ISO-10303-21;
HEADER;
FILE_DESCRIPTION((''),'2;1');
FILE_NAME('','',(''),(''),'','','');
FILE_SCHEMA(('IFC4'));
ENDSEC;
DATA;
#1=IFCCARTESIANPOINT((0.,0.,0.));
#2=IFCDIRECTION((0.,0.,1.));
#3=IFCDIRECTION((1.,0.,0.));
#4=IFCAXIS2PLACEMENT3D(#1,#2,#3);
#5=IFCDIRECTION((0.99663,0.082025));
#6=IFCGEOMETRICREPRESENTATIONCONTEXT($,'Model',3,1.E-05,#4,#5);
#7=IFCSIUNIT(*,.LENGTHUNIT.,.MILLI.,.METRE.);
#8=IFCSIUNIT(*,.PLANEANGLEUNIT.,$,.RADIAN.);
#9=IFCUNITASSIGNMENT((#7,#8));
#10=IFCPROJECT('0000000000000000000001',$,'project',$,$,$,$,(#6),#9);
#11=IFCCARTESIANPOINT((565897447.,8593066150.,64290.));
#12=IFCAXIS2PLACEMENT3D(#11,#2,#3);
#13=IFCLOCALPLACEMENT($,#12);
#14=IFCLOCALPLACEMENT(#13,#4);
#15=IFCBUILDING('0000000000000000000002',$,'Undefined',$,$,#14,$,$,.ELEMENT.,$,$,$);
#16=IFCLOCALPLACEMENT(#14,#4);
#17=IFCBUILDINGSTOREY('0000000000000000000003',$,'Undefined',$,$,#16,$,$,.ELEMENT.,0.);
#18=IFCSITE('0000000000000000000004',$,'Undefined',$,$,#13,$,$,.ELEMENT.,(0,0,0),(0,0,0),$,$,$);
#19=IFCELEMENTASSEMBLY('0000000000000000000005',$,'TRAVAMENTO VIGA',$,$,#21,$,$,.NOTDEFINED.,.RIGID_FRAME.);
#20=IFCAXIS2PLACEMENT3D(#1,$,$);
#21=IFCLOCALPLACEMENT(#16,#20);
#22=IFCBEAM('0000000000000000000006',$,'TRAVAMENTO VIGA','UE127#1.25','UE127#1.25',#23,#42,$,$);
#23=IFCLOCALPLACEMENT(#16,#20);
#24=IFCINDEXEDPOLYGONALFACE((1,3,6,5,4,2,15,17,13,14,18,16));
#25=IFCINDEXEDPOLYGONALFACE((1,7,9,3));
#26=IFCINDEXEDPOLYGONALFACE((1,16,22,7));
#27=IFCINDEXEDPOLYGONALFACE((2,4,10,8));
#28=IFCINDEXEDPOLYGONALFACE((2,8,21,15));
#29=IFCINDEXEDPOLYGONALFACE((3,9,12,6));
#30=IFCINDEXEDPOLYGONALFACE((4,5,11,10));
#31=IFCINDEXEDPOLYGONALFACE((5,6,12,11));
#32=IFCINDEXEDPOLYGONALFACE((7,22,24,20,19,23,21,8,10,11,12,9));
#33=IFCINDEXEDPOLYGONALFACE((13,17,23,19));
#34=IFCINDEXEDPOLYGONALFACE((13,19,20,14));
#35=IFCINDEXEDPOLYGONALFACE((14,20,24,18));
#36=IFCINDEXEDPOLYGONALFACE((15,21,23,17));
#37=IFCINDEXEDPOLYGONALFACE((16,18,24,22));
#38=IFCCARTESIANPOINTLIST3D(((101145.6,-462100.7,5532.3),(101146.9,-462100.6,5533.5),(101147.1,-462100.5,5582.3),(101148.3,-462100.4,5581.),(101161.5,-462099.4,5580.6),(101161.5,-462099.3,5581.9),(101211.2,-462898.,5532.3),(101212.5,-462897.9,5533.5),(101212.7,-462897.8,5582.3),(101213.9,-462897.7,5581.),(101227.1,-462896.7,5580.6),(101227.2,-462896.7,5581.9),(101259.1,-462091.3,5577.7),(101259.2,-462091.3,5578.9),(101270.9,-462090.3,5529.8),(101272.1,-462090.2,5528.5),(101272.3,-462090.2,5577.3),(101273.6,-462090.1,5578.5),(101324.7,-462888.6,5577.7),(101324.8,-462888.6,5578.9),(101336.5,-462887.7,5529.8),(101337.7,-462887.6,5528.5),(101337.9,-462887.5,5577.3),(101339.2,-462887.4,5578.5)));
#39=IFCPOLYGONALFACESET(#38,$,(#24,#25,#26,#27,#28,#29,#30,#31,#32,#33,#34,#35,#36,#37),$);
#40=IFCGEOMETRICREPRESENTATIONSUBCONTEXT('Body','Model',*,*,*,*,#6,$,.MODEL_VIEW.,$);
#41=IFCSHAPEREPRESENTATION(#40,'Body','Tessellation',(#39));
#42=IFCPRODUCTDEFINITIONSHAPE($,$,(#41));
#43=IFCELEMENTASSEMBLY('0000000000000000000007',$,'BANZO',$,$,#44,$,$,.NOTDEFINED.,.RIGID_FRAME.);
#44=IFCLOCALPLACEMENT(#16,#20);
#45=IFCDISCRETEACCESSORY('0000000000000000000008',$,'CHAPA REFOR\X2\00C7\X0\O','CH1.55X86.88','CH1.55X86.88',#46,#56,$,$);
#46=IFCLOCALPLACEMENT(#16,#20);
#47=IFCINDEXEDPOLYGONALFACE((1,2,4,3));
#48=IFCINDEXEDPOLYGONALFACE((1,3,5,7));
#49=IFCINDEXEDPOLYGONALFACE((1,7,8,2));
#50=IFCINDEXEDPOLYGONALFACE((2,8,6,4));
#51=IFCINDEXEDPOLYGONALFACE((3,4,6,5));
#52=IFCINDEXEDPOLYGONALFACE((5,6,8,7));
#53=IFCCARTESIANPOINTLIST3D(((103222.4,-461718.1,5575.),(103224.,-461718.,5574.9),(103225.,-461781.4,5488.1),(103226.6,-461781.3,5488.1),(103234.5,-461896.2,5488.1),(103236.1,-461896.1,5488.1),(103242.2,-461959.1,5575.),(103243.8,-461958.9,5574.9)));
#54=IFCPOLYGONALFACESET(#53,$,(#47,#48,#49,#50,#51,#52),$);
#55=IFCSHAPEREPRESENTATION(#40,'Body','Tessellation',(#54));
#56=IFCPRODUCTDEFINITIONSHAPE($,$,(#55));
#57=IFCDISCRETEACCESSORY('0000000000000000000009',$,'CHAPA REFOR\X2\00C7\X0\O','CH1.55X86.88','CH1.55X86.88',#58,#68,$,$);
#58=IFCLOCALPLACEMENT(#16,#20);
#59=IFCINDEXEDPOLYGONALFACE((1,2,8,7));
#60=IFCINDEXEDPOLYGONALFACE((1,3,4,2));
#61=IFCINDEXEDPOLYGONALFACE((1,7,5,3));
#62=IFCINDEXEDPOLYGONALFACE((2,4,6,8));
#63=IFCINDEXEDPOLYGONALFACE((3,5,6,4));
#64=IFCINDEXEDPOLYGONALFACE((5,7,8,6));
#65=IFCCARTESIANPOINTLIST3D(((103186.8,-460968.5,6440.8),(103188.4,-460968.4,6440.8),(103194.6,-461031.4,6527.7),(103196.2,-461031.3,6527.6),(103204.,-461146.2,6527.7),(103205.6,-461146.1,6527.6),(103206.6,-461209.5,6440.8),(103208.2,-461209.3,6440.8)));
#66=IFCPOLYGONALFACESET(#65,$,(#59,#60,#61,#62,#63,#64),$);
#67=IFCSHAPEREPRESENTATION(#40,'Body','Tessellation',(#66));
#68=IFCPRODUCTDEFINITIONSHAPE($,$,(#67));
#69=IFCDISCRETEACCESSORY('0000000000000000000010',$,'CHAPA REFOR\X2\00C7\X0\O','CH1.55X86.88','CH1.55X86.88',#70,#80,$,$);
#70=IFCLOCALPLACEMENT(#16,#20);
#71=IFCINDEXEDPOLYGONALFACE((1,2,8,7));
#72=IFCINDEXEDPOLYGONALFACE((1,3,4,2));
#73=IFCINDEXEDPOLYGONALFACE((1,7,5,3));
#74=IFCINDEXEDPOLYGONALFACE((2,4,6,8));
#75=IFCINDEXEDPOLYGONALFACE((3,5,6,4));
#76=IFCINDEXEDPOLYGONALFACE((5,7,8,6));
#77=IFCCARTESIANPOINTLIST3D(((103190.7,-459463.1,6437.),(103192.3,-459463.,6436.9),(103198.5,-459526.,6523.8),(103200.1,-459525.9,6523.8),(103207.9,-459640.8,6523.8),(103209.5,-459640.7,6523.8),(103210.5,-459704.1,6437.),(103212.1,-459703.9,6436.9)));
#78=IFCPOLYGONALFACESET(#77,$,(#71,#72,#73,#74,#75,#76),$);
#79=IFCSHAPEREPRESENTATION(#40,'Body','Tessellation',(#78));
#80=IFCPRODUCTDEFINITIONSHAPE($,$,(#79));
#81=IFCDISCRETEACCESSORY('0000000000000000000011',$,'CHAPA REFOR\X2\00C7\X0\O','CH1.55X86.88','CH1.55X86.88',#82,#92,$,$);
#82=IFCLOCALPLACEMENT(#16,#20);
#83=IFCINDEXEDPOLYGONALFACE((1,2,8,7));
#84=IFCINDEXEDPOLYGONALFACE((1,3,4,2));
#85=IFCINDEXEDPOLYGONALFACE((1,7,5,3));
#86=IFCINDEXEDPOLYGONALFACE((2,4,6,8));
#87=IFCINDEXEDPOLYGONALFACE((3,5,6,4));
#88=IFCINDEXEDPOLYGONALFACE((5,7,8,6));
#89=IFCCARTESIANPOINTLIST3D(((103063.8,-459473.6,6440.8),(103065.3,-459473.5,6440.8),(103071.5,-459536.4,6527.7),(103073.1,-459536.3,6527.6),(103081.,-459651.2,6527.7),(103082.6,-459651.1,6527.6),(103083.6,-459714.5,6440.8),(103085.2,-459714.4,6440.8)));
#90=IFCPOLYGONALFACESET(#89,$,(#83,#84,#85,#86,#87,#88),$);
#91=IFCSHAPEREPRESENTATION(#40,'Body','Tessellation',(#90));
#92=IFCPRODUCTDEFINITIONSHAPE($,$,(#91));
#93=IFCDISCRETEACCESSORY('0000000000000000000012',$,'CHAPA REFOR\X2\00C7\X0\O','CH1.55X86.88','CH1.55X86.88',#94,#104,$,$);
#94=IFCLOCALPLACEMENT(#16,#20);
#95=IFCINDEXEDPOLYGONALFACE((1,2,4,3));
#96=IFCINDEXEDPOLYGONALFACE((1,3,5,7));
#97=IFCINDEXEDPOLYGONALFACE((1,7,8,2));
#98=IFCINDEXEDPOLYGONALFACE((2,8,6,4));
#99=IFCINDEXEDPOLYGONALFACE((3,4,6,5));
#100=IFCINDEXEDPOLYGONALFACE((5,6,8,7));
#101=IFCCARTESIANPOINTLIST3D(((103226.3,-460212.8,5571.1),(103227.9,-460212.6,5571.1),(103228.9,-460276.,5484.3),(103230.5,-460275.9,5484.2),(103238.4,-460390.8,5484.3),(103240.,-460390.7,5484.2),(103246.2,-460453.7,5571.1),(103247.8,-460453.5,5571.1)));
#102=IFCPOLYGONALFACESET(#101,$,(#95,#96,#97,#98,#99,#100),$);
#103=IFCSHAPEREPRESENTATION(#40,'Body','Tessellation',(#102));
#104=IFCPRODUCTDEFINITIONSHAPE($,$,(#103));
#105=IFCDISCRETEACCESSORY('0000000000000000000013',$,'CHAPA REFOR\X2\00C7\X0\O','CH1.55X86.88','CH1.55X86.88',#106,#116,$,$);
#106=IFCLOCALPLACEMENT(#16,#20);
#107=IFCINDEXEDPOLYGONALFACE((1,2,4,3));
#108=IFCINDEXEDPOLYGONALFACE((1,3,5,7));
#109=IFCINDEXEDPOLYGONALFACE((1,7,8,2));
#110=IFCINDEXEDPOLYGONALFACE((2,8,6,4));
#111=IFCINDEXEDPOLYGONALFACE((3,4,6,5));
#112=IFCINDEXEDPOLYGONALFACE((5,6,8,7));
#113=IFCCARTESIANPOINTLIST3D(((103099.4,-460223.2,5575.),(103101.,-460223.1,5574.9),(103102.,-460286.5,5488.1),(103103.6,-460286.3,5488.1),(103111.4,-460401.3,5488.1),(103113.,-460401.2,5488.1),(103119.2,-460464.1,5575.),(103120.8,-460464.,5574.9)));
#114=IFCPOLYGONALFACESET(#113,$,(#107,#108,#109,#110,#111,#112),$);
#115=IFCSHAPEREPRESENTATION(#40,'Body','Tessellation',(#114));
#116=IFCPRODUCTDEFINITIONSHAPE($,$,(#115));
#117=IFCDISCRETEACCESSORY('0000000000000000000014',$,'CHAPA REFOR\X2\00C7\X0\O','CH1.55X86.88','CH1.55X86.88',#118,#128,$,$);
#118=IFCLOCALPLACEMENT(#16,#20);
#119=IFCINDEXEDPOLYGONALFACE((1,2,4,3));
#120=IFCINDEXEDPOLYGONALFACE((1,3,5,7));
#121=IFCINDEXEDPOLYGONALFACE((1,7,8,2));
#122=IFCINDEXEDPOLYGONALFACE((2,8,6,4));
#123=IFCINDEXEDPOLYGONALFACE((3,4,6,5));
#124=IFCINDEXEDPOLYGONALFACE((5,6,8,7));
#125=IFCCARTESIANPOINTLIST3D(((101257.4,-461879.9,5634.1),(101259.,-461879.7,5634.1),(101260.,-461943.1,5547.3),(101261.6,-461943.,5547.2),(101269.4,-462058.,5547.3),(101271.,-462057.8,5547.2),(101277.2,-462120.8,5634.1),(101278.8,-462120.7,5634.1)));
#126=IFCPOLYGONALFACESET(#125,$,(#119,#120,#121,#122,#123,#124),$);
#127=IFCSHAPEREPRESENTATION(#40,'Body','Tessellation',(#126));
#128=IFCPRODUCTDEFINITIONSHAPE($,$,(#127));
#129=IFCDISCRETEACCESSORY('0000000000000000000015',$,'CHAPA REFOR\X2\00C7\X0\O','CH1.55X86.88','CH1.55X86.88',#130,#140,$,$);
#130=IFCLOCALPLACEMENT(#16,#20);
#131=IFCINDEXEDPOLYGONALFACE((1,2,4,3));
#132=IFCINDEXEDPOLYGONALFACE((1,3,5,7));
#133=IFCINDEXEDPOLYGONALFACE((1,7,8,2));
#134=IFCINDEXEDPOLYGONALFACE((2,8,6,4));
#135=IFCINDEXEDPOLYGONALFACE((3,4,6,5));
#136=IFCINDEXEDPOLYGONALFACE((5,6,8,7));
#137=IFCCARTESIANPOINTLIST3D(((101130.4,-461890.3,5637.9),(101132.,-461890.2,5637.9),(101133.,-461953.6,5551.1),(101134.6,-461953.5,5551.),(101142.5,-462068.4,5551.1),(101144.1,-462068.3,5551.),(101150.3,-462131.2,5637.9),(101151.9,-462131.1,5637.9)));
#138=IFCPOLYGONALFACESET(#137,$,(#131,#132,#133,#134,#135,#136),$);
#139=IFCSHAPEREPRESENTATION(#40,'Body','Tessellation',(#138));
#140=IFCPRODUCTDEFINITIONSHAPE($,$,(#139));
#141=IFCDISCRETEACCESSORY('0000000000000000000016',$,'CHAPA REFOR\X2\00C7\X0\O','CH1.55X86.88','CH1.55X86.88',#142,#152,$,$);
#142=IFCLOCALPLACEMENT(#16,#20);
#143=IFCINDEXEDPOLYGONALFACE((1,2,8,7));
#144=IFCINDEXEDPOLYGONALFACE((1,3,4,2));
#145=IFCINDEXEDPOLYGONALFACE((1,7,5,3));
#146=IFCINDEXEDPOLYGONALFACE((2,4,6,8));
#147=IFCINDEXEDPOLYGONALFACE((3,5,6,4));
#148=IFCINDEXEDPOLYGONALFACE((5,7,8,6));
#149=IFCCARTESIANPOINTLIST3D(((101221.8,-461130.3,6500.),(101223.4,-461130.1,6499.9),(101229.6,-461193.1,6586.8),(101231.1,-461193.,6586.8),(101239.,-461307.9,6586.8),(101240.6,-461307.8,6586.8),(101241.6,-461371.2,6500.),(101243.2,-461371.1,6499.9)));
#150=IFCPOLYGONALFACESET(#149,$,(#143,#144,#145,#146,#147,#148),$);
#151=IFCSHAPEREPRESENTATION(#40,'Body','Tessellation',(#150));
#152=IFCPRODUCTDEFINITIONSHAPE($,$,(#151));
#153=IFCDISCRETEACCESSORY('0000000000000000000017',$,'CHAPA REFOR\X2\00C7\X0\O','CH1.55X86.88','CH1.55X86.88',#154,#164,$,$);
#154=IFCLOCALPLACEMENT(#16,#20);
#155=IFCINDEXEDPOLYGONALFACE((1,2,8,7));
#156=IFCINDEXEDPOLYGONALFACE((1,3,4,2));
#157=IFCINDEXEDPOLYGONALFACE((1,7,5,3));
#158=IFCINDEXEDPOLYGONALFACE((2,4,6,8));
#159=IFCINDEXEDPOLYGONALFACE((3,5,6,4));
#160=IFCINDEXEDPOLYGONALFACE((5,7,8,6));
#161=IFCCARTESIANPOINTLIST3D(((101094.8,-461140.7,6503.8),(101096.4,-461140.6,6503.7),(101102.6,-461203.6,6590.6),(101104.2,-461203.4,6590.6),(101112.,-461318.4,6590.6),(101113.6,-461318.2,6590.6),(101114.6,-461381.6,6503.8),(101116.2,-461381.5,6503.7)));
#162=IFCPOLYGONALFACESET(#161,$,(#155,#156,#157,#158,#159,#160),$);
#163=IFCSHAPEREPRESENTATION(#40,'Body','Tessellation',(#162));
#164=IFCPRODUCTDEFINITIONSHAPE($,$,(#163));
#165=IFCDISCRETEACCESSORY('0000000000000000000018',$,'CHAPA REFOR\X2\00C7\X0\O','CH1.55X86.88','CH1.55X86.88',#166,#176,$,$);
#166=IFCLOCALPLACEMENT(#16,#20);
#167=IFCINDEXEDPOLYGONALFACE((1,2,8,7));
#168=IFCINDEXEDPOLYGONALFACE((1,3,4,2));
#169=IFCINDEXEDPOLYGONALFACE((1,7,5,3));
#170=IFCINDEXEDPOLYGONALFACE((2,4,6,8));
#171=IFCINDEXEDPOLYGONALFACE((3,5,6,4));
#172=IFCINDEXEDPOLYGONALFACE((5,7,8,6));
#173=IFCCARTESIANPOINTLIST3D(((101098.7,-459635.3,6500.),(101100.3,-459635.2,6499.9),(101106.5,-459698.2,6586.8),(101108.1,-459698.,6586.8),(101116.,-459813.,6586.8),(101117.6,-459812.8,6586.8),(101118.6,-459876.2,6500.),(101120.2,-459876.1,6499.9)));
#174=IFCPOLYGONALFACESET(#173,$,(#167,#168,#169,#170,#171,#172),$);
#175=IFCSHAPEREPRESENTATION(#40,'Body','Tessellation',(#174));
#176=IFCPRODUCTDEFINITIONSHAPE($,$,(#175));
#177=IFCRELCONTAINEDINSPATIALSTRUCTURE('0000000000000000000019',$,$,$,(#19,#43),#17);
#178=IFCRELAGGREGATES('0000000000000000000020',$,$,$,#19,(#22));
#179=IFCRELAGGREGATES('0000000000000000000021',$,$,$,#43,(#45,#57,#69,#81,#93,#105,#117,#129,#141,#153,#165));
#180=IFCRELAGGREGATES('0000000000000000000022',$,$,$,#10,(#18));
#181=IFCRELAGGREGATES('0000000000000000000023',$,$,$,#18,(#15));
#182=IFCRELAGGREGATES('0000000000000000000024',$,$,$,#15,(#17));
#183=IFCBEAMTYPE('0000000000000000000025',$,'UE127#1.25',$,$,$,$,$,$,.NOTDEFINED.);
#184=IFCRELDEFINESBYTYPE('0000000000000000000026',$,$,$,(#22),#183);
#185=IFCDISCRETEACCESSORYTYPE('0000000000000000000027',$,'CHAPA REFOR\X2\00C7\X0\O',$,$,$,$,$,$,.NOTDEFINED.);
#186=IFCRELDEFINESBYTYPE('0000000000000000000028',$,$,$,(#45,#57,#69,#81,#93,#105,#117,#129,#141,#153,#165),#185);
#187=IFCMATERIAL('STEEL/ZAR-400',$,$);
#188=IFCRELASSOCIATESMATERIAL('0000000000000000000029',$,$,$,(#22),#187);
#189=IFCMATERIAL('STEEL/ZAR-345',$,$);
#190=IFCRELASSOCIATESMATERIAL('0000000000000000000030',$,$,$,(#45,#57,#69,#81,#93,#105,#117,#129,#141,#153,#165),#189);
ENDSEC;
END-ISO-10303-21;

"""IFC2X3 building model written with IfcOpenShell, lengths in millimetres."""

from ifc_helpers import new_model, si_unit, direction, frame, frame_2d, origin_with_axes, place, context, subcontext, project, spatial, polyline, c_section, outline, extrude, material, type_object, element, aggregate, save


model = new_model("IFC2X3")

# Units and contexts
model_context = context("Model", 3, precision=1e-05, world=origin_with_axes(), true_north=direction((0.99663, 0.082025)))
body_context = subcontext(model_context, "Body", "Model", "MODEL_VIEW")
ifc_project = project(units=[si_unit("LENGTHUNIT", "METRE", prefix="MILLI"), si_unit("PLANEANGLEUNIT", "RADIAN")], contexts=[model_context])

# Site, building, storey
site_placement = place(None, frame((565897447.0, 8593066150.0, 64290.0), z_axis=(0.0, 0.0, 1.0), x_axis=(1.0, 0.0, 0.0)))
site = spatial("IfcSite", under=ifc_project, at=site_placement, Name="Undefined", CompositionType="ELEMENT", RefLatitude=(0, 0, 0), RefLongitude=(0, 0, 0))
building_placement = place(site_placement, origin_with_axes())
building = spatial("IfcBuilding", under=site, at=building_placement, Name="Undefined", CompositionType="ELEMENT")
storey_placement = place(building_placement, origin_with_axes())
storey = spatial("IfcBuildingStorey", under=building, at=storey_placement, Name="Undefined", CompositionType="ELEMENT", Elevation=0.0)

# Element assembly, beam
assembly_1_placement = place(storey_placement, origin_with_axes())
assembly_1 = element("IfcElementAssembly", 1, at=assembly_1_placement, inside=storey, Name="TRAVAMENTO VIGA", AssemblyPlace="NOTDEFINED", PredefinedType="RIGID_FRAME")
ifc_material_1 = material(Name="STEEL/ZAR-400")
beam_type = type_object("IfcBeamType", Name="UE127#1.25", PredefinedType="NOTDEFINED")
beam_placement = place(assembly_1_placement, frame((101209.6, -462095.4, 5555.4), z_axis=(0.996182, 0.081989, -0.029987), x_axis=(0.082025, -0.99663, 0.0)))
beam = element("IfcBeam", 2, at=beam_placement, type_object=beam_type, material=ifc_material_1, Name="TRAVAMENTO VIGA", Description="UE127#1.25", ObjectType="UE127#1.25", context=body_context, shape_type="SweptSolid", body=[
    extrude(c_section(Depth=127.0, Width=50.0, WallThickness=1.2, Girth=14.5, at=frame_2d((0.0, 0.0), x_axis=(1.0, 0.0))), frame((800.0, 0.0, 0.0), z_axis=(-1.0, 0.0, 0.0), x_axis=(0.0, -1.0, 0.0)), (0.0, 0.0, 1.0), 800.0),
])
aggregate(assembly_1, [beam])

# Element assembly, discrete accessories
assembly_2_placement = place(storey_placement, origin_with_axes())
assembly_2 = element("IfcElementAssembly", 3, at=assembly_2_placement, inside=storey, Name="BANZO", AssemblyPlace="NOTDEFINED", PredefinedType="RIGID_FRAME")
ifc_material_2 = material(Name="STEEL/ZAR-345")
discrete_accessory_type_1 = type_object("IfcDiscreteAccessoryType", Name="CHAPA REFORÇO")
discrete_accessory_1_placement = place(assembly_2_placement, frame((103223.2, -461718.1, 5574.9), z_axis=(0.996182, 0.081989, -0.029987), x_axis=(0.082025, -0.99663, 0.0)))
discrete_accessory_1 = element("IfcDiscreteAccessory", 4, at=discrete_accessory_1_placement, type_object=discrete_accessory_type_1, material=ifc_material_2, Name="CHAPA REFORÇO", Description="CH1.55X86.88", ObjectType="CH1.55X86.88", context=body_context, shape_type="SweptSolid", body=[
    extrude(outline(polyline([(0.0, 0.0), (241.7, 0.0), (178.5, 86.9), (63.3, 86.9), (0.0, 0.0)])), frame((0.0, 0.0, -0.8), z_axis=(0.0, 0.0, 1.0), x_axis=(1.0, 0.0, 0.0)), (0.0, 0.0, 1.0), 1.6),
])
discrete_accessory_2_placement = place(assembly_2_placement, frame((103207.4, -461209.4, 6440.8), z_axis=(0.996182, 0.081989, -0.029987), x_axis=(-0.082025, 0.99663, 0.0)))
discrete_accessory_2 = element("IfcDiscreteAccessory", 5, at=discrete_accessory_2_placement, type_object=discrete_accessory_type_1, material=ifc_material_2, Name="CHAPA REFORÇO", Description="CH1.55X86.88", ObjectType="CH1.55X86.88", context=body_context, shape_type="SweptSolid", body=[
    extrude(outline(polyline([(0.0, 0.0), (241.7, 0.0), (178.5, 86.9), (63.3, 86.9), (0.0, 0.0)])), frame((0.0, 0.0, -0.8), z_axis=(0.0, 0.0, 1.0), x_axis=(1.0, 0.0, 0.0)), (0.0, 0.0, 1.0), 1.6),
])
discrete_accessory_3_placement = place(assembly_2_placement, frame((103211.3, -459704.0, 6437.0), z_axis=(0.996182, 0.081989, -0.029987), x_axis=(-0.082025, 0.99663, 0.0)))
discrete_accessory_3 = element("IfcDiscreteAccessory", 6, at=discrete_accessory_3_placement, type_object=discrete_accessory_type_1, material=ifc_material_2, Name="CHAPA REFORÇO", Description="CH1.55X86.88", ObjectType="CH1.55X86.88", context=body_context, shape_type="SweptSolid", body=[
    extrude(outline(polyline([(0.0, 0.0), (241.7, 0.0), (178.5, 86.9), (63.3, 86.9), (0.0, 0.0)])), frame((0.0, 0.0, -0.8), z_axis=(0.0, 0.0, 1.0), x_axis=(1.0, 0.0, 0.0)), (0.0, 0.0, 1.0), 1.6),
])
discrete_accessory_4_placement = place(assembly_2_placement, frame((103084.4, -459714.5, 6440.8), z_axis=(0.996182, 0.081989, -0.029987), x_axis=(-0.082025, 0.99663, 0.0)))
discrete_accessory_4 = element("IfcDiscreteAccessory", 7, at=discrete_accessory_4_placement, type_object=discrete_accessory_type_1, material=ifc_material_2, Name="CHAPA REFORÇO", Description="CH1.55X86.88", ObjectType="CH1.55X86.88", context=body_context, shape_type="SweptSolid", body=[
    extrude(outline(polyline([(0.0, 0.0), (241.7, 0.0), (178.5, 86.9), (63.3, 86.9), (0.0, 0.0)])), frame((0.0, 0.0, -0.8), z_axis=(0.0, 0.0, 1.0), x_axis=(1.0, 0.0, 0.0)), (0.0, 0.0, 1.0), 1.6),
])
discrete_accessory_5_placement = place(assembly_2_placement, frame((103227.1, -460212.7, 5571.1), z_axis=(0.996182, 0.081989, -0.029987), x_axis=(0.082025, -0.99663, 0.0)))
discrete_accessory_5 = element("IfcDiscreteAccessory", 8, at=discrete_accessory_5_placement, type_object=discrete_accessory_type_1, material=ifc_material_2, Name="CHAPA REFORÇO", Description="CH1.55X86.88", ObjectType="CH1.55X86.88", context=body_context, shape_type="SweptSolid", body=[
    extrude(outline(polyline([(0.0, 0.0), (241.7, 0.0), (178.5, 86.9), (63.3, 86.9), (0.0, 0.0)])), frame((0.0, 0.0, -0.8), z_axis=(0.0, 0.0, 1.0), x_axis=(1.0, 0.0, 0.0)), (0.0, 0.0, 1.0), 1.6),
])
discrete_accessory_6_placement = place(assembly_2_placement, frame((103100.2, -460223.1, 5574.9), z_axis=(0.996182, 0.081989, -0.029987), x_axis=(0.082025, -0.99663, 0.0)))
discrete_accessory_6 = element("IfcDiscreteAccessory", 9, at=discrete_accessory_6_placement, type_object=discrete_accessory_type_1, material=ifc_material_2, Name="CHAPA REFORÇO", Description="CH1.55X86.88", ObjectType="CH1.55X86.88", context=body_context, shape_type="SweptSolid", body=[
    extrude(outline(polyline([(0.0, 0.0), (241.7, 0.0), (178.5, 86.9), (63.3, 86.9), (0.0, 0.0)])), frame((0.0, 0.0, -0.8), z_axis=(0.0, 0.0, 1.0), x_axis=(1.0, 0.0, 0.0)), (0.0, 0.0, 1.0), 1.6),
])
discrete_accessory_7_placement = place(assembly_2_placement, frame((101258.2, -461879.8, 5634.1), z_axis=(0.996182, 0.081989, -0.029987), x_axis=(0.082025, -0.99663, 0.0)))
discrete_accessory_7 = element("IfcDiscreteAccessory", 10, at=discrete_accessory_7_placement, type_object=discrete_accessory_type_1, material=ifc_material_2, Name="CHAPA REFORÇO", Description="CH1.55X86.88", ObjectType="CH1.55X86.88", context=body_context, shape_type="SweptSolid", body=[
    extrude(outline(polyline([(0.0, 0.0), (241.7, 0.0), (178.5, 86.9), (63.3, 86.9), (0.0, 0.0)])), frame((0.0, 0.0, -0.8), z_axis=(0.0, 0.0, 1.0), x_axis=(1.0, 0.0, 0.0)), (0.0, 0.0, 1.0), 1.6),
])
discrete_accessory_8_placement = place(assembly_2_placement, frame((101131.2, -461890.3, 5637.9), z_axis=(0.996182, 0.081989, -0.029987), x_axis=(0.082025, -0.99663, 0.0)))
discrete_accessory_8 = element("IfcDiscreteAccessory", 11, at=discrete_accessory_8_placement, type_object=discrete_accessory_type_1, material=ifc_material_2, Name="CHAPA REFORÇO", Description="CH1.55X86.88", ObjectType="CH1.55X86.88", context=body_context, shape_type="SweptSolid", body=[
    extrude(outline(polyline([(0.0, 0.0), (241.7, 0.0), (178.5, 86.9), (63.3, 86.9), (0.0, 0.0)])), frame((0.0, 0.0, -0.8), z_axis=(0.0, 0.0, 1.0), x_axis=(1.0, 0.0, 0.0)), (0.0, 0.0, 1.0), 1.6),
])
discrete_accessory_9_placement = place(assembly_2_placement, frame((101242.4, -461371.1, 6499.9), z_axis=(0.996182, 0.081989, -0.029987), x_axis=(-0.082025, 0.99663, 0.0)))
discrete_accessory_9 = element("IfcDiscreteAccessory", 12, at=discrete_accessory_9_placement, type_object=discrete_accessory_type_1, material=ifc_material_2, Name="CHAPA REFORÇO", Description="CH1.55X86.88", ObjectType="CH1.55X86.88", context=body_context, shape_type="SweptSolid", body=[
    extrude(outline(polyline([(0.0, 0.0), (241.7, 0.0), (178.5, 86.9), (63.3, 86.9), (0.0, 0.0)])), frame((0.0, 0.0, -0.8), z_axis=(0.0, 0.0, 1.0), x_axis=(1.0, 0.0, 0.0)), (0.0, 0.0, 1.0), 1.6),
])
discrete_accessory_10_placement = place(assembly_2_placement, frame((101115.4, -461381.6, 6503.8), z_axis=(0.996182, 0.081989, -0.029987), x_axis=(-0.082025, 0.99663, 0.0)))
discrete_accessory_10 = element("IfcDiscreteAccessory", 13, at=discrete_accessory_10_placement, type_object=discrete_accessory_type_1, material=ifc_material_2, Name="CHAPA REFORÇO", Description="CH1.55X86.88", ObjectType="CH1.55X86.88", context=body_context, shape_type="SweptSolid", body=[
    extrude(outline(polyline([(0.0, 0.0), (241.7, 0.0), (178.5, 86.9), (63.3, 86.9), (0.0, 0.0)])), frame((0.0, 0.0, -0.8), z_axis=(0.0, 0.0, 1.0), x_axis=(1.0, 0.0, 0.0)), (0.0, 0.0, 1.0), 1.6),
])
discrete_accessory_11_placement = place(assembly_2_placement, frame((101119.4, -459876.2, 6499.9), z_axis=(0.996182, 0.081989, -0.029987), x_axis=(-0.082025, 0.99663, 0.0)))
discrete_accessory_11 = element("IfcDiscreteAccessory", 14, at=discrete_accessory_11_placement, type_object=discrete_accessory_type_1, material=ifc_material_2, Name="CHAPA REFORÇO", Description="CH1.55X86.88", ObjectType="CH1.55X86.88", context=body_context, shape_type="SweptSolid", body=[
    extrude(outline(polyline([(0.0, 0.0), (241.7, 0.0), (178.5, 86.9), (63.3, 86.9), (0.0, 0.0)])), frame((0.0, 0.0, -0.8), z_axis=(0.0, 0.0, 1.0), x_axis=(1.0, 0.0, 0.0)), (0.0, 0.0, 1.0), 1.6),
])
aggregate(assembly_2, [discrete_accessory_1, discrete_accessory_2, discrete_accessory_3, discrete_accessory_4, discrete_accessory_5, discrete_accessory_6, discrete_accessory_7, discrete_accessory_8, discrete_accessory_9, discrete_accessory_10, discrete_accessory_11])

save(model, "model.ifc")
